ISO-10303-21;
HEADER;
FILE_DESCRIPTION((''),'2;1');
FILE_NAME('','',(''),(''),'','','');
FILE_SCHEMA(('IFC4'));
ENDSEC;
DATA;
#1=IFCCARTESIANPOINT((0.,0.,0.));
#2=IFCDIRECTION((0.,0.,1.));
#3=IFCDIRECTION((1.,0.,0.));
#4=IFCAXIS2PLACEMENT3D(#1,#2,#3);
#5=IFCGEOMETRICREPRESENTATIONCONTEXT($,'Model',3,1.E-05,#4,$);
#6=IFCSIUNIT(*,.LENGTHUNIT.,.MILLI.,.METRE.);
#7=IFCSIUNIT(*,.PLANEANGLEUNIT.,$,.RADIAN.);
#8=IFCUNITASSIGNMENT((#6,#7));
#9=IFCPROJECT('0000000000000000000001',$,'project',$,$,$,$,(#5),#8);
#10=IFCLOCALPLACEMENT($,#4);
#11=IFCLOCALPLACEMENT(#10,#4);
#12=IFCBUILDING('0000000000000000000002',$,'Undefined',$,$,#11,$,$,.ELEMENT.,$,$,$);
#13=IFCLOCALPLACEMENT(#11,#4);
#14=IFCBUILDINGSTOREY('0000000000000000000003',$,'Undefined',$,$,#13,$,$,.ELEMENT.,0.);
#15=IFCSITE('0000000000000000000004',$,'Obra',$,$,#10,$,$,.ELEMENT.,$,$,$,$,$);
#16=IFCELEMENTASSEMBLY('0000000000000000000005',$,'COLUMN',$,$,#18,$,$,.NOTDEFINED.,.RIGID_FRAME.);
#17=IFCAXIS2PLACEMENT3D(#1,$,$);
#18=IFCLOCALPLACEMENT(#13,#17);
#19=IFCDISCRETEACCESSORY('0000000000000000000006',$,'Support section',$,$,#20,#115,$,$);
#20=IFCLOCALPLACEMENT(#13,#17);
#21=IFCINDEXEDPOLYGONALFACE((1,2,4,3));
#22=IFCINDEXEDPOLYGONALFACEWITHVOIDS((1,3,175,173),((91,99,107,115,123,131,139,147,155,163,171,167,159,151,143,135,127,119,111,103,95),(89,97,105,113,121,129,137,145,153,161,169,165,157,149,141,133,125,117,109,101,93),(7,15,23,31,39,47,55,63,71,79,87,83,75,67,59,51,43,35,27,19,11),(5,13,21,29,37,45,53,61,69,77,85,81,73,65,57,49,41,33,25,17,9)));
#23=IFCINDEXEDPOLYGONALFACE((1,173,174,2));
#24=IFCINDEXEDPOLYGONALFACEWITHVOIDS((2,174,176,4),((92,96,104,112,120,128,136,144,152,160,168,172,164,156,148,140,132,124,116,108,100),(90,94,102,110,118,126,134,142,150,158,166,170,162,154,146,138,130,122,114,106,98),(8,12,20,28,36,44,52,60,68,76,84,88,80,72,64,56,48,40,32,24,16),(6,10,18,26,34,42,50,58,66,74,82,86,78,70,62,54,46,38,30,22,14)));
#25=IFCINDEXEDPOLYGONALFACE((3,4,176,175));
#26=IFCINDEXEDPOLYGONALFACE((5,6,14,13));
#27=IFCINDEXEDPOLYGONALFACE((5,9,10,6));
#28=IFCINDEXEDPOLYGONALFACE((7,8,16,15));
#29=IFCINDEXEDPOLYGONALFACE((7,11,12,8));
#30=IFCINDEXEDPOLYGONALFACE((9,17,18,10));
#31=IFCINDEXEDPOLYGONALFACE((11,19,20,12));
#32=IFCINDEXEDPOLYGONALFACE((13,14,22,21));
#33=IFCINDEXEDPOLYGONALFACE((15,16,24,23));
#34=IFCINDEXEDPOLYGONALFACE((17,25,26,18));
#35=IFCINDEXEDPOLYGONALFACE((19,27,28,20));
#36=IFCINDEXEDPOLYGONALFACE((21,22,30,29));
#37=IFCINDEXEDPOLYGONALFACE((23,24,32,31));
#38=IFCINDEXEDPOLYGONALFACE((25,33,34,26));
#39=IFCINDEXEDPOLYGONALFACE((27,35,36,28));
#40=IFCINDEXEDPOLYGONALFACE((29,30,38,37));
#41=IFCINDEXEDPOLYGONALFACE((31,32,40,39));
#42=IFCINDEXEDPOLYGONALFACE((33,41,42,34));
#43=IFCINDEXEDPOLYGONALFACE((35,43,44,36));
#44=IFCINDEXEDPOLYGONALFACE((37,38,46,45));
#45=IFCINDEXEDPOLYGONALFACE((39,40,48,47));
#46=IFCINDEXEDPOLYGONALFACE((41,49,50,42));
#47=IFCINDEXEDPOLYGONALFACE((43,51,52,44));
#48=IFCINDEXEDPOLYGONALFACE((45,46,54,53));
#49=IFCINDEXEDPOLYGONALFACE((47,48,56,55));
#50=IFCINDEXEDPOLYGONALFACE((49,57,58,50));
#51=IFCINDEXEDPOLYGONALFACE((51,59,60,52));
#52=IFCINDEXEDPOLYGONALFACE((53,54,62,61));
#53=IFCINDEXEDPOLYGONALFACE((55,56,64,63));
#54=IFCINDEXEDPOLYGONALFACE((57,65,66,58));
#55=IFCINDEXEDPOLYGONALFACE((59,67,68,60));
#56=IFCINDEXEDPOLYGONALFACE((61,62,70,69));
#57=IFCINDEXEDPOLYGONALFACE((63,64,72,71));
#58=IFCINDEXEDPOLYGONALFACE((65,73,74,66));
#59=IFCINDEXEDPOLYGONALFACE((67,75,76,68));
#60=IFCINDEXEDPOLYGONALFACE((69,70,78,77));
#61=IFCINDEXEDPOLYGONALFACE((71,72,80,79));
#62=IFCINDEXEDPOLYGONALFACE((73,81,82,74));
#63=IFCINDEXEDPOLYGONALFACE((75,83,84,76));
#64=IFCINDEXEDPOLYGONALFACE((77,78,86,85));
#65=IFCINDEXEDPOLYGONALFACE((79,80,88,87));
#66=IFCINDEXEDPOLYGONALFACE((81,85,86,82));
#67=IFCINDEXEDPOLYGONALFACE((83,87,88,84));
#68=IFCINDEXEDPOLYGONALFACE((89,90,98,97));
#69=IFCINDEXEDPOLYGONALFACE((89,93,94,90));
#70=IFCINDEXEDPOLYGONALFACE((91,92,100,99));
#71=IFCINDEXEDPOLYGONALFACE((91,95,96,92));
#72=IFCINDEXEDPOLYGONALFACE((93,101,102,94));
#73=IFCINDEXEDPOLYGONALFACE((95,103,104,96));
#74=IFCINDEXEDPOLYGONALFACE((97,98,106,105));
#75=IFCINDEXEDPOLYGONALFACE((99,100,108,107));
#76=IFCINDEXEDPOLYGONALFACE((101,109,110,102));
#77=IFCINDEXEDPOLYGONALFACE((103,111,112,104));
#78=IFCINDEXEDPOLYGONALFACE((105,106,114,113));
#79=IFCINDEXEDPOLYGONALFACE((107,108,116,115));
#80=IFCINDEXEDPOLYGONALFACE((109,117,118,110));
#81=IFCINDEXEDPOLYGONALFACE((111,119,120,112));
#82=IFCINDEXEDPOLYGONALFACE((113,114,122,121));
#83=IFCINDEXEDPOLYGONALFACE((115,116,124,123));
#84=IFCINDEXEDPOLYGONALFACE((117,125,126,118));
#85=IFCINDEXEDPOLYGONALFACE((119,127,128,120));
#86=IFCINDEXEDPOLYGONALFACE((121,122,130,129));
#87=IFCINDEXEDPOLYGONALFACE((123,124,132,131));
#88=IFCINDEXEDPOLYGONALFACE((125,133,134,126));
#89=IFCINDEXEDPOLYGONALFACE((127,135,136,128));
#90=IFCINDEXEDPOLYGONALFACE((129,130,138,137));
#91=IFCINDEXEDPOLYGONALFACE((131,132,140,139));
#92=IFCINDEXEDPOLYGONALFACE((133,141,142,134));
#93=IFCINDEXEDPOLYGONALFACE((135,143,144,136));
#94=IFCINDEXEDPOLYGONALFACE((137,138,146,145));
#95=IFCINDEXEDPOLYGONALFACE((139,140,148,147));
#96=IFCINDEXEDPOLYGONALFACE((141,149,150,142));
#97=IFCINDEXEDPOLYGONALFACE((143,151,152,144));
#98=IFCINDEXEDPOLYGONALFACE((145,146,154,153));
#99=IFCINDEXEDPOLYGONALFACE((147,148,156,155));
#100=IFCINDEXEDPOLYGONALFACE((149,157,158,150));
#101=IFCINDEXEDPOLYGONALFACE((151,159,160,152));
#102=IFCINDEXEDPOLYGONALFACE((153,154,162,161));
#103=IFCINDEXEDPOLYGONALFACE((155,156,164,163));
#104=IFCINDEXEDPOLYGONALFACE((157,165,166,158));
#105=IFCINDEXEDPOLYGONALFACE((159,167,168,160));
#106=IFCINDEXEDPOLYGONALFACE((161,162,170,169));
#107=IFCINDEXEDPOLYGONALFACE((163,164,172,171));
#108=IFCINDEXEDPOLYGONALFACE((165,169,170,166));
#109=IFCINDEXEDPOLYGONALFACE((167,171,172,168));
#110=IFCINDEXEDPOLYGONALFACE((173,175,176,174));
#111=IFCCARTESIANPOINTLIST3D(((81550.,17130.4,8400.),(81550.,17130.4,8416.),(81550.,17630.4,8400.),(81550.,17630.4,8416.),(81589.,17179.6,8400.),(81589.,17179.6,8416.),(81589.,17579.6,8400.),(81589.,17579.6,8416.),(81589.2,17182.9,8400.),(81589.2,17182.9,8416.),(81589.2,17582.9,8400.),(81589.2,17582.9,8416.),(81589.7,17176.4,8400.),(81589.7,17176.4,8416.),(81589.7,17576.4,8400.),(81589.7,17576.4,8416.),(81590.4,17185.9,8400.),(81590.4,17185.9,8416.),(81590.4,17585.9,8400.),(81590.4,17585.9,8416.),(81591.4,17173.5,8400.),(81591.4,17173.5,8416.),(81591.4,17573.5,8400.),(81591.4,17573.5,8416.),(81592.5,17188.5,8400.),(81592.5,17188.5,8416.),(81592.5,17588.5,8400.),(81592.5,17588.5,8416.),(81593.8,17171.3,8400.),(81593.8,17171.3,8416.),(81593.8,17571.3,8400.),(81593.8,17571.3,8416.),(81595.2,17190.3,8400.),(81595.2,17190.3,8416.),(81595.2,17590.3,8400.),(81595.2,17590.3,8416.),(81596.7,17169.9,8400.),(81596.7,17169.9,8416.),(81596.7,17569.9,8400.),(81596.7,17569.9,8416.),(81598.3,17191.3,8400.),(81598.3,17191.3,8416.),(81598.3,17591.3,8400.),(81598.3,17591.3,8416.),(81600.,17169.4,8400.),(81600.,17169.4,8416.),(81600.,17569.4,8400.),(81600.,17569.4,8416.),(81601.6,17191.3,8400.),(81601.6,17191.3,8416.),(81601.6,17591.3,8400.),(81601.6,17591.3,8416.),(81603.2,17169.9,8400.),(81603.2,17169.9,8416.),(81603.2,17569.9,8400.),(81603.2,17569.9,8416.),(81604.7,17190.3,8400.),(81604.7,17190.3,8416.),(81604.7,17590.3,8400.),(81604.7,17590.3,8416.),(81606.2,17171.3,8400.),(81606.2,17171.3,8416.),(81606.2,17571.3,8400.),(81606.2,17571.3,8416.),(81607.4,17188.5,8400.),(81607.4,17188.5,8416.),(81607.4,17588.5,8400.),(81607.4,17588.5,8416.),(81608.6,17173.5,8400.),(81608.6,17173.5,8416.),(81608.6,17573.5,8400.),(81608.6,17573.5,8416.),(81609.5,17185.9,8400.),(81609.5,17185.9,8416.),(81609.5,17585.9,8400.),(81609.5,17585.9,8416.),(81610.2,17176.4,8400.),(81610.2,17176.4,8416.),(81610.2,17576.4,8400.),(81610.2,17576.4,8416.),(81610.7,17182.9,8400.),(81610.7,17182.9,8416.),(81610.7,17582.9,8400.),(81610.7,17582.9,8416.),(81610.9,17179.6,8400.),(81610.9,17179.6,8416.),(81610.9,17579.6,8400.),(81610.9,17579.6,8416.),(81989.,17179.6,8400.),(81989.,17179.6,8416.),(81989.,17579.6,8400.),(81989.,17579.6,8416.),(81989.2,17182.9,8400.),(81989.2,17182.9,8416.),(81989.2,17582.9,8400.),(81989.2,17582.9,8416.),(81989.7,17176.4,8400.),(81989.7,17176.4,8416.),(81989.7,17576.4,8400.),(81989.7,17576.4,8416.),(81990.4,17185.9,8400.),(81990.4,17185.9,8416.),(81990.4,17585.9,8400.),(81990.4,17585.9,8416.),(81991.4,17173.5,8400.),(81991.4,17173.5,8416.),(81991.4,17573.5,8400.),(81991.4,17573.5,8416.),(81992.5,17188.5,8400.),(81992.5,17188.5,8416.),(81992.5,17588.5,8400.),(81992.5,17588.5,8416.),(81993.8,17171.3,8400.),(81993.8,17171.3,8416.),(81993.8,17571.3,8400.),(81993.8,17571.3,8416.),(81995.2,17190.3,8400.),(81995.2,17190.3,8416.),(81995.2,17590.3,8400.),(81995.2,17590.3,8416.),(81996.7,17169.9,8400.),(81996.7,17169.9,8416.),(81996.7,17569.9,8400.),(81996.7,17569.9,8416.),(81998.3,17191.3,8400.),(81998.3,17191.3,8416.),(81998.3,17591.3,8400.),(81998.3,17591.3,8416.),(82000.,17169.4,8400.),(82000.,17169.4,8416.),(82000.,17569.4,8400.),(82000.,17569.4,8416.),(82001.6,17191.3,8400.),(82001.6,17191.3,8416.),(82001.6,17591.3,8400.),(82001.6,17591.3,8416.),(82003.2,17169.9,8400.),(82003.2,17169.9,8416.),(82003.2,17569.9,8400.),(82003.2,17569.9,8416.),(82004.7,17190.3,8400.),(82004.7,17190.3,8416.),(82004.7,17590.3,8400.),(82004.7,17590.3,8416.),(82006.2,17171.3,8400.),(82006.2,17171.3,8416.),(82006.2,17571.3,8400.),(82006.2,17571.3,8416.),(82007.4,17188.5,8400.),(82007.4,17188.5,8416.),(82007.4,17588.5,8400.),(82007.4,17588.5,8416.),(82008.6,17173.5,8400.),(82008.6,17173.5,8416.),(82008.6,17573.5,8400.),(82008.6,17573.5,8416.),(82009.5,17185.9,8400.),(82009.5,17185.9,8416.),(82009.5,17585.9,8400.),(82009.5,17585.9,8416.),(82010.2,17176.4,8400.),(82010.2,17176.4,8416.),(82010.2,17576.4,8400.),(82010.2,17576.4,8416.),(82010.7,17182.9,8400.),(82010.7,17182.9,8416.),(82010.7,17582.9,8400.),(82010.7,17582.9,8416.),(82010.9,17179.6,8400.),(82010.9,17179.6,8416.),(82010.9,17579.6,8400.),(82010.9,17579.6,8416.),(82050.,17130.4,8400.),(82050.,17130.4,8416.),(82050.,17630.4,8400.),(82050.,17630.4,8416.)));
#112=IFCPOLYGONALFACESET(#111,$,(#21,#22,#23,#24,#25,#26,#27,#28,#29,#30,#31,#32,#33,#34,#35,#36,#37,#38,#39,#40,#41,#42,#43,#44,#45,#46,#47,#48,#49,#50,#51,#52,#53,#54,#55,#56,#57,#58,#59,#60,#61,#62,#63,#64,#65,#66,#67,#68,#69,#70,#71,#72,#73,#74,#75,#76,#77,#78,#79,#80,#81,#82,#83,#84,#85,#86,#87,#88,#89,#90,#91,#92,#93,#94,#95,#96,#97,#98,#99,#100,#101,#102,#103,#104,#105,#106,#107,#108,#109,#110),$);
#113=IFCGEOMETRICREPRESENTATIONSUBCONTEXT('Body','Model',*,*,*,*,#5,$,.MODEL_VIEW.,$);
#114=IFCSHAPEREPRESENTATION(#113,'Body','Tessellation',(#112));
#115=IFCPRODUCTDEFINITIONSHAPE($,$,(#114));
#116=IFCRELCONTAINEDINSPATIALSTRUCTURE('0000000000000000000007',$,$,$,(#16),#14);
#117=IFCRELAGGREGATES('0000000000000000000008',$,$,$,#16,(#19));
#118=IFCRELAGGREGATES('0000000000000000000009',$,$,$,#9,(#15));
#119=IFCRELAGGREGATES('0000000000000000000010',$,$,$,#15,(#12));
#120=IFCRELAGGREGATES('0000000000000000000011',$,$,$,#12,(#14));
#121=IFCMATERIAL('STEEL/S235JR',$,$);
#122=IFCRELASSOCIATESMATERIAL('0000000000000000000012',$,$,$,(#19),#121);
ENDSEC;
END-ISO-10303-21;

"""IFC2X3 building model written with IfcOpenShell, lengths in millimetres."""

from ifc_helpers import new_model, si_unit, frame, origin_with_axes, origin_2d_with_axis, place, context, subcontext, project, spatial, rectangle, circle, extrude, source, transform, mapped, material, element, aggregate, save


model = new_model("IFC2X3")

# Units and contexts
model_context = context("Model", 3, precision=1e-05, world=origin_with_axes())
body_context = subcontext(model_context, "Body", "Model", "MODEL_VIEW")
ifc_project = project(units=[si_unit("LENGTHUNIT", "METRE", prefix="MILLI"), si_unit("PLANEANGLEUNIT", "RADIAN")], contexts=[model_context])

# Site, building, storey
site_placement = place(None, origin_with_axes())
site = spatial("IfcSite", under=ifc_project, at=site_placement, Name="Obra", CompositionType="ELEMENT")
building_placement = place(site_placement, origin_with_axes())
building = spatial("IfcBuilding", under=site, at=building_placement, Name="Undefined", CompositionType="ELEMENT")
storey_placement = place(building_placement, origin_with_axes())
storey = spatial("IfcBuildingStorey", under=building, at=storey_placement, Name="Undefined", CompositionType="ELEMENT", Elevation=0.0)

# Shared definitions
ifc_material_1 = material(Name="STEEL/S235JR")

# Element assembly, discrete accessory, opening
assembly_1_placement = place(storey_placement, origin_with_axes())
assembly_1 = element("IfcElementAssembly", 1, at=assembly_1_placement, inside=storey, Name="COLUMN", AssemblyPlace="NOTDEFINED", PredefinedType="RIGID_FRAME")
discrete_accessory_1_placement = place(assembly_1_placement, frame((81800.0, 17130.4, 8408.0), z_axis=(-1.0, 0.0, 0.0), x_axis=(0.0, 1.0, 0.0)))
discrete_accessory_1 = element("IfcDiscreteAccessory", 2, at=discrete_accessory_1_placement, material=ifc_material_1, Name="Support section", context=body_context, shape_type="SweptSolid", body=[
    extrude(rectangle(XDim=16.0, YDim=500.0, at=origin_2d_with_axis()), frame((500.0, 0.0, 0.0), z_axis=(-1.0, 0.0, 0.0), x_axis=(0.0, -1.0, 0.0)), (0.0, 0.0, 1.0), 500.0),
])
shared_shape_1 = source(origin_with_axes(), body_context, "Body", "SweptSolid", [
    extrude(circle(Radius=11.0, at=origin_2d_with_axis()), frame((0.0, -0.1, 0.0), z_axis=(0.0, 1.0, 0.0), x_axis=(1.0, 0.0, 0.0)), (0.0, 0.0, 1.0), 16.2),
])
opening_1_placement = place(assembly_1_placement, frame((81800.0, 17583.4, 8416.0), z_axis=(1.0, 0.0, 0.0), x_axis=(0.0, -1.0, 0.0)))
element("IfcOpeningElement", 3, at=opening_1_placement, cuts=discrete_accessory_1, ObjectType="Opening", context=body_context, shape_type="MappedRepresentation", body=[
    mapped(shared_shape_1, transform((3.0, 0.0, 200.0))),
    mapped(shared_shape_1, transform((3.0, 0.0, -200.0))),
    mapped(shared_shape_1, transform((403.0, 0.0, 200.0))),
    mapped(shared_shape_1, transform((403.0, 0.0, -200.0))),
])
aggregate(assembly_1, [discrete_accessory_1])

save(model, "model.ifc")
